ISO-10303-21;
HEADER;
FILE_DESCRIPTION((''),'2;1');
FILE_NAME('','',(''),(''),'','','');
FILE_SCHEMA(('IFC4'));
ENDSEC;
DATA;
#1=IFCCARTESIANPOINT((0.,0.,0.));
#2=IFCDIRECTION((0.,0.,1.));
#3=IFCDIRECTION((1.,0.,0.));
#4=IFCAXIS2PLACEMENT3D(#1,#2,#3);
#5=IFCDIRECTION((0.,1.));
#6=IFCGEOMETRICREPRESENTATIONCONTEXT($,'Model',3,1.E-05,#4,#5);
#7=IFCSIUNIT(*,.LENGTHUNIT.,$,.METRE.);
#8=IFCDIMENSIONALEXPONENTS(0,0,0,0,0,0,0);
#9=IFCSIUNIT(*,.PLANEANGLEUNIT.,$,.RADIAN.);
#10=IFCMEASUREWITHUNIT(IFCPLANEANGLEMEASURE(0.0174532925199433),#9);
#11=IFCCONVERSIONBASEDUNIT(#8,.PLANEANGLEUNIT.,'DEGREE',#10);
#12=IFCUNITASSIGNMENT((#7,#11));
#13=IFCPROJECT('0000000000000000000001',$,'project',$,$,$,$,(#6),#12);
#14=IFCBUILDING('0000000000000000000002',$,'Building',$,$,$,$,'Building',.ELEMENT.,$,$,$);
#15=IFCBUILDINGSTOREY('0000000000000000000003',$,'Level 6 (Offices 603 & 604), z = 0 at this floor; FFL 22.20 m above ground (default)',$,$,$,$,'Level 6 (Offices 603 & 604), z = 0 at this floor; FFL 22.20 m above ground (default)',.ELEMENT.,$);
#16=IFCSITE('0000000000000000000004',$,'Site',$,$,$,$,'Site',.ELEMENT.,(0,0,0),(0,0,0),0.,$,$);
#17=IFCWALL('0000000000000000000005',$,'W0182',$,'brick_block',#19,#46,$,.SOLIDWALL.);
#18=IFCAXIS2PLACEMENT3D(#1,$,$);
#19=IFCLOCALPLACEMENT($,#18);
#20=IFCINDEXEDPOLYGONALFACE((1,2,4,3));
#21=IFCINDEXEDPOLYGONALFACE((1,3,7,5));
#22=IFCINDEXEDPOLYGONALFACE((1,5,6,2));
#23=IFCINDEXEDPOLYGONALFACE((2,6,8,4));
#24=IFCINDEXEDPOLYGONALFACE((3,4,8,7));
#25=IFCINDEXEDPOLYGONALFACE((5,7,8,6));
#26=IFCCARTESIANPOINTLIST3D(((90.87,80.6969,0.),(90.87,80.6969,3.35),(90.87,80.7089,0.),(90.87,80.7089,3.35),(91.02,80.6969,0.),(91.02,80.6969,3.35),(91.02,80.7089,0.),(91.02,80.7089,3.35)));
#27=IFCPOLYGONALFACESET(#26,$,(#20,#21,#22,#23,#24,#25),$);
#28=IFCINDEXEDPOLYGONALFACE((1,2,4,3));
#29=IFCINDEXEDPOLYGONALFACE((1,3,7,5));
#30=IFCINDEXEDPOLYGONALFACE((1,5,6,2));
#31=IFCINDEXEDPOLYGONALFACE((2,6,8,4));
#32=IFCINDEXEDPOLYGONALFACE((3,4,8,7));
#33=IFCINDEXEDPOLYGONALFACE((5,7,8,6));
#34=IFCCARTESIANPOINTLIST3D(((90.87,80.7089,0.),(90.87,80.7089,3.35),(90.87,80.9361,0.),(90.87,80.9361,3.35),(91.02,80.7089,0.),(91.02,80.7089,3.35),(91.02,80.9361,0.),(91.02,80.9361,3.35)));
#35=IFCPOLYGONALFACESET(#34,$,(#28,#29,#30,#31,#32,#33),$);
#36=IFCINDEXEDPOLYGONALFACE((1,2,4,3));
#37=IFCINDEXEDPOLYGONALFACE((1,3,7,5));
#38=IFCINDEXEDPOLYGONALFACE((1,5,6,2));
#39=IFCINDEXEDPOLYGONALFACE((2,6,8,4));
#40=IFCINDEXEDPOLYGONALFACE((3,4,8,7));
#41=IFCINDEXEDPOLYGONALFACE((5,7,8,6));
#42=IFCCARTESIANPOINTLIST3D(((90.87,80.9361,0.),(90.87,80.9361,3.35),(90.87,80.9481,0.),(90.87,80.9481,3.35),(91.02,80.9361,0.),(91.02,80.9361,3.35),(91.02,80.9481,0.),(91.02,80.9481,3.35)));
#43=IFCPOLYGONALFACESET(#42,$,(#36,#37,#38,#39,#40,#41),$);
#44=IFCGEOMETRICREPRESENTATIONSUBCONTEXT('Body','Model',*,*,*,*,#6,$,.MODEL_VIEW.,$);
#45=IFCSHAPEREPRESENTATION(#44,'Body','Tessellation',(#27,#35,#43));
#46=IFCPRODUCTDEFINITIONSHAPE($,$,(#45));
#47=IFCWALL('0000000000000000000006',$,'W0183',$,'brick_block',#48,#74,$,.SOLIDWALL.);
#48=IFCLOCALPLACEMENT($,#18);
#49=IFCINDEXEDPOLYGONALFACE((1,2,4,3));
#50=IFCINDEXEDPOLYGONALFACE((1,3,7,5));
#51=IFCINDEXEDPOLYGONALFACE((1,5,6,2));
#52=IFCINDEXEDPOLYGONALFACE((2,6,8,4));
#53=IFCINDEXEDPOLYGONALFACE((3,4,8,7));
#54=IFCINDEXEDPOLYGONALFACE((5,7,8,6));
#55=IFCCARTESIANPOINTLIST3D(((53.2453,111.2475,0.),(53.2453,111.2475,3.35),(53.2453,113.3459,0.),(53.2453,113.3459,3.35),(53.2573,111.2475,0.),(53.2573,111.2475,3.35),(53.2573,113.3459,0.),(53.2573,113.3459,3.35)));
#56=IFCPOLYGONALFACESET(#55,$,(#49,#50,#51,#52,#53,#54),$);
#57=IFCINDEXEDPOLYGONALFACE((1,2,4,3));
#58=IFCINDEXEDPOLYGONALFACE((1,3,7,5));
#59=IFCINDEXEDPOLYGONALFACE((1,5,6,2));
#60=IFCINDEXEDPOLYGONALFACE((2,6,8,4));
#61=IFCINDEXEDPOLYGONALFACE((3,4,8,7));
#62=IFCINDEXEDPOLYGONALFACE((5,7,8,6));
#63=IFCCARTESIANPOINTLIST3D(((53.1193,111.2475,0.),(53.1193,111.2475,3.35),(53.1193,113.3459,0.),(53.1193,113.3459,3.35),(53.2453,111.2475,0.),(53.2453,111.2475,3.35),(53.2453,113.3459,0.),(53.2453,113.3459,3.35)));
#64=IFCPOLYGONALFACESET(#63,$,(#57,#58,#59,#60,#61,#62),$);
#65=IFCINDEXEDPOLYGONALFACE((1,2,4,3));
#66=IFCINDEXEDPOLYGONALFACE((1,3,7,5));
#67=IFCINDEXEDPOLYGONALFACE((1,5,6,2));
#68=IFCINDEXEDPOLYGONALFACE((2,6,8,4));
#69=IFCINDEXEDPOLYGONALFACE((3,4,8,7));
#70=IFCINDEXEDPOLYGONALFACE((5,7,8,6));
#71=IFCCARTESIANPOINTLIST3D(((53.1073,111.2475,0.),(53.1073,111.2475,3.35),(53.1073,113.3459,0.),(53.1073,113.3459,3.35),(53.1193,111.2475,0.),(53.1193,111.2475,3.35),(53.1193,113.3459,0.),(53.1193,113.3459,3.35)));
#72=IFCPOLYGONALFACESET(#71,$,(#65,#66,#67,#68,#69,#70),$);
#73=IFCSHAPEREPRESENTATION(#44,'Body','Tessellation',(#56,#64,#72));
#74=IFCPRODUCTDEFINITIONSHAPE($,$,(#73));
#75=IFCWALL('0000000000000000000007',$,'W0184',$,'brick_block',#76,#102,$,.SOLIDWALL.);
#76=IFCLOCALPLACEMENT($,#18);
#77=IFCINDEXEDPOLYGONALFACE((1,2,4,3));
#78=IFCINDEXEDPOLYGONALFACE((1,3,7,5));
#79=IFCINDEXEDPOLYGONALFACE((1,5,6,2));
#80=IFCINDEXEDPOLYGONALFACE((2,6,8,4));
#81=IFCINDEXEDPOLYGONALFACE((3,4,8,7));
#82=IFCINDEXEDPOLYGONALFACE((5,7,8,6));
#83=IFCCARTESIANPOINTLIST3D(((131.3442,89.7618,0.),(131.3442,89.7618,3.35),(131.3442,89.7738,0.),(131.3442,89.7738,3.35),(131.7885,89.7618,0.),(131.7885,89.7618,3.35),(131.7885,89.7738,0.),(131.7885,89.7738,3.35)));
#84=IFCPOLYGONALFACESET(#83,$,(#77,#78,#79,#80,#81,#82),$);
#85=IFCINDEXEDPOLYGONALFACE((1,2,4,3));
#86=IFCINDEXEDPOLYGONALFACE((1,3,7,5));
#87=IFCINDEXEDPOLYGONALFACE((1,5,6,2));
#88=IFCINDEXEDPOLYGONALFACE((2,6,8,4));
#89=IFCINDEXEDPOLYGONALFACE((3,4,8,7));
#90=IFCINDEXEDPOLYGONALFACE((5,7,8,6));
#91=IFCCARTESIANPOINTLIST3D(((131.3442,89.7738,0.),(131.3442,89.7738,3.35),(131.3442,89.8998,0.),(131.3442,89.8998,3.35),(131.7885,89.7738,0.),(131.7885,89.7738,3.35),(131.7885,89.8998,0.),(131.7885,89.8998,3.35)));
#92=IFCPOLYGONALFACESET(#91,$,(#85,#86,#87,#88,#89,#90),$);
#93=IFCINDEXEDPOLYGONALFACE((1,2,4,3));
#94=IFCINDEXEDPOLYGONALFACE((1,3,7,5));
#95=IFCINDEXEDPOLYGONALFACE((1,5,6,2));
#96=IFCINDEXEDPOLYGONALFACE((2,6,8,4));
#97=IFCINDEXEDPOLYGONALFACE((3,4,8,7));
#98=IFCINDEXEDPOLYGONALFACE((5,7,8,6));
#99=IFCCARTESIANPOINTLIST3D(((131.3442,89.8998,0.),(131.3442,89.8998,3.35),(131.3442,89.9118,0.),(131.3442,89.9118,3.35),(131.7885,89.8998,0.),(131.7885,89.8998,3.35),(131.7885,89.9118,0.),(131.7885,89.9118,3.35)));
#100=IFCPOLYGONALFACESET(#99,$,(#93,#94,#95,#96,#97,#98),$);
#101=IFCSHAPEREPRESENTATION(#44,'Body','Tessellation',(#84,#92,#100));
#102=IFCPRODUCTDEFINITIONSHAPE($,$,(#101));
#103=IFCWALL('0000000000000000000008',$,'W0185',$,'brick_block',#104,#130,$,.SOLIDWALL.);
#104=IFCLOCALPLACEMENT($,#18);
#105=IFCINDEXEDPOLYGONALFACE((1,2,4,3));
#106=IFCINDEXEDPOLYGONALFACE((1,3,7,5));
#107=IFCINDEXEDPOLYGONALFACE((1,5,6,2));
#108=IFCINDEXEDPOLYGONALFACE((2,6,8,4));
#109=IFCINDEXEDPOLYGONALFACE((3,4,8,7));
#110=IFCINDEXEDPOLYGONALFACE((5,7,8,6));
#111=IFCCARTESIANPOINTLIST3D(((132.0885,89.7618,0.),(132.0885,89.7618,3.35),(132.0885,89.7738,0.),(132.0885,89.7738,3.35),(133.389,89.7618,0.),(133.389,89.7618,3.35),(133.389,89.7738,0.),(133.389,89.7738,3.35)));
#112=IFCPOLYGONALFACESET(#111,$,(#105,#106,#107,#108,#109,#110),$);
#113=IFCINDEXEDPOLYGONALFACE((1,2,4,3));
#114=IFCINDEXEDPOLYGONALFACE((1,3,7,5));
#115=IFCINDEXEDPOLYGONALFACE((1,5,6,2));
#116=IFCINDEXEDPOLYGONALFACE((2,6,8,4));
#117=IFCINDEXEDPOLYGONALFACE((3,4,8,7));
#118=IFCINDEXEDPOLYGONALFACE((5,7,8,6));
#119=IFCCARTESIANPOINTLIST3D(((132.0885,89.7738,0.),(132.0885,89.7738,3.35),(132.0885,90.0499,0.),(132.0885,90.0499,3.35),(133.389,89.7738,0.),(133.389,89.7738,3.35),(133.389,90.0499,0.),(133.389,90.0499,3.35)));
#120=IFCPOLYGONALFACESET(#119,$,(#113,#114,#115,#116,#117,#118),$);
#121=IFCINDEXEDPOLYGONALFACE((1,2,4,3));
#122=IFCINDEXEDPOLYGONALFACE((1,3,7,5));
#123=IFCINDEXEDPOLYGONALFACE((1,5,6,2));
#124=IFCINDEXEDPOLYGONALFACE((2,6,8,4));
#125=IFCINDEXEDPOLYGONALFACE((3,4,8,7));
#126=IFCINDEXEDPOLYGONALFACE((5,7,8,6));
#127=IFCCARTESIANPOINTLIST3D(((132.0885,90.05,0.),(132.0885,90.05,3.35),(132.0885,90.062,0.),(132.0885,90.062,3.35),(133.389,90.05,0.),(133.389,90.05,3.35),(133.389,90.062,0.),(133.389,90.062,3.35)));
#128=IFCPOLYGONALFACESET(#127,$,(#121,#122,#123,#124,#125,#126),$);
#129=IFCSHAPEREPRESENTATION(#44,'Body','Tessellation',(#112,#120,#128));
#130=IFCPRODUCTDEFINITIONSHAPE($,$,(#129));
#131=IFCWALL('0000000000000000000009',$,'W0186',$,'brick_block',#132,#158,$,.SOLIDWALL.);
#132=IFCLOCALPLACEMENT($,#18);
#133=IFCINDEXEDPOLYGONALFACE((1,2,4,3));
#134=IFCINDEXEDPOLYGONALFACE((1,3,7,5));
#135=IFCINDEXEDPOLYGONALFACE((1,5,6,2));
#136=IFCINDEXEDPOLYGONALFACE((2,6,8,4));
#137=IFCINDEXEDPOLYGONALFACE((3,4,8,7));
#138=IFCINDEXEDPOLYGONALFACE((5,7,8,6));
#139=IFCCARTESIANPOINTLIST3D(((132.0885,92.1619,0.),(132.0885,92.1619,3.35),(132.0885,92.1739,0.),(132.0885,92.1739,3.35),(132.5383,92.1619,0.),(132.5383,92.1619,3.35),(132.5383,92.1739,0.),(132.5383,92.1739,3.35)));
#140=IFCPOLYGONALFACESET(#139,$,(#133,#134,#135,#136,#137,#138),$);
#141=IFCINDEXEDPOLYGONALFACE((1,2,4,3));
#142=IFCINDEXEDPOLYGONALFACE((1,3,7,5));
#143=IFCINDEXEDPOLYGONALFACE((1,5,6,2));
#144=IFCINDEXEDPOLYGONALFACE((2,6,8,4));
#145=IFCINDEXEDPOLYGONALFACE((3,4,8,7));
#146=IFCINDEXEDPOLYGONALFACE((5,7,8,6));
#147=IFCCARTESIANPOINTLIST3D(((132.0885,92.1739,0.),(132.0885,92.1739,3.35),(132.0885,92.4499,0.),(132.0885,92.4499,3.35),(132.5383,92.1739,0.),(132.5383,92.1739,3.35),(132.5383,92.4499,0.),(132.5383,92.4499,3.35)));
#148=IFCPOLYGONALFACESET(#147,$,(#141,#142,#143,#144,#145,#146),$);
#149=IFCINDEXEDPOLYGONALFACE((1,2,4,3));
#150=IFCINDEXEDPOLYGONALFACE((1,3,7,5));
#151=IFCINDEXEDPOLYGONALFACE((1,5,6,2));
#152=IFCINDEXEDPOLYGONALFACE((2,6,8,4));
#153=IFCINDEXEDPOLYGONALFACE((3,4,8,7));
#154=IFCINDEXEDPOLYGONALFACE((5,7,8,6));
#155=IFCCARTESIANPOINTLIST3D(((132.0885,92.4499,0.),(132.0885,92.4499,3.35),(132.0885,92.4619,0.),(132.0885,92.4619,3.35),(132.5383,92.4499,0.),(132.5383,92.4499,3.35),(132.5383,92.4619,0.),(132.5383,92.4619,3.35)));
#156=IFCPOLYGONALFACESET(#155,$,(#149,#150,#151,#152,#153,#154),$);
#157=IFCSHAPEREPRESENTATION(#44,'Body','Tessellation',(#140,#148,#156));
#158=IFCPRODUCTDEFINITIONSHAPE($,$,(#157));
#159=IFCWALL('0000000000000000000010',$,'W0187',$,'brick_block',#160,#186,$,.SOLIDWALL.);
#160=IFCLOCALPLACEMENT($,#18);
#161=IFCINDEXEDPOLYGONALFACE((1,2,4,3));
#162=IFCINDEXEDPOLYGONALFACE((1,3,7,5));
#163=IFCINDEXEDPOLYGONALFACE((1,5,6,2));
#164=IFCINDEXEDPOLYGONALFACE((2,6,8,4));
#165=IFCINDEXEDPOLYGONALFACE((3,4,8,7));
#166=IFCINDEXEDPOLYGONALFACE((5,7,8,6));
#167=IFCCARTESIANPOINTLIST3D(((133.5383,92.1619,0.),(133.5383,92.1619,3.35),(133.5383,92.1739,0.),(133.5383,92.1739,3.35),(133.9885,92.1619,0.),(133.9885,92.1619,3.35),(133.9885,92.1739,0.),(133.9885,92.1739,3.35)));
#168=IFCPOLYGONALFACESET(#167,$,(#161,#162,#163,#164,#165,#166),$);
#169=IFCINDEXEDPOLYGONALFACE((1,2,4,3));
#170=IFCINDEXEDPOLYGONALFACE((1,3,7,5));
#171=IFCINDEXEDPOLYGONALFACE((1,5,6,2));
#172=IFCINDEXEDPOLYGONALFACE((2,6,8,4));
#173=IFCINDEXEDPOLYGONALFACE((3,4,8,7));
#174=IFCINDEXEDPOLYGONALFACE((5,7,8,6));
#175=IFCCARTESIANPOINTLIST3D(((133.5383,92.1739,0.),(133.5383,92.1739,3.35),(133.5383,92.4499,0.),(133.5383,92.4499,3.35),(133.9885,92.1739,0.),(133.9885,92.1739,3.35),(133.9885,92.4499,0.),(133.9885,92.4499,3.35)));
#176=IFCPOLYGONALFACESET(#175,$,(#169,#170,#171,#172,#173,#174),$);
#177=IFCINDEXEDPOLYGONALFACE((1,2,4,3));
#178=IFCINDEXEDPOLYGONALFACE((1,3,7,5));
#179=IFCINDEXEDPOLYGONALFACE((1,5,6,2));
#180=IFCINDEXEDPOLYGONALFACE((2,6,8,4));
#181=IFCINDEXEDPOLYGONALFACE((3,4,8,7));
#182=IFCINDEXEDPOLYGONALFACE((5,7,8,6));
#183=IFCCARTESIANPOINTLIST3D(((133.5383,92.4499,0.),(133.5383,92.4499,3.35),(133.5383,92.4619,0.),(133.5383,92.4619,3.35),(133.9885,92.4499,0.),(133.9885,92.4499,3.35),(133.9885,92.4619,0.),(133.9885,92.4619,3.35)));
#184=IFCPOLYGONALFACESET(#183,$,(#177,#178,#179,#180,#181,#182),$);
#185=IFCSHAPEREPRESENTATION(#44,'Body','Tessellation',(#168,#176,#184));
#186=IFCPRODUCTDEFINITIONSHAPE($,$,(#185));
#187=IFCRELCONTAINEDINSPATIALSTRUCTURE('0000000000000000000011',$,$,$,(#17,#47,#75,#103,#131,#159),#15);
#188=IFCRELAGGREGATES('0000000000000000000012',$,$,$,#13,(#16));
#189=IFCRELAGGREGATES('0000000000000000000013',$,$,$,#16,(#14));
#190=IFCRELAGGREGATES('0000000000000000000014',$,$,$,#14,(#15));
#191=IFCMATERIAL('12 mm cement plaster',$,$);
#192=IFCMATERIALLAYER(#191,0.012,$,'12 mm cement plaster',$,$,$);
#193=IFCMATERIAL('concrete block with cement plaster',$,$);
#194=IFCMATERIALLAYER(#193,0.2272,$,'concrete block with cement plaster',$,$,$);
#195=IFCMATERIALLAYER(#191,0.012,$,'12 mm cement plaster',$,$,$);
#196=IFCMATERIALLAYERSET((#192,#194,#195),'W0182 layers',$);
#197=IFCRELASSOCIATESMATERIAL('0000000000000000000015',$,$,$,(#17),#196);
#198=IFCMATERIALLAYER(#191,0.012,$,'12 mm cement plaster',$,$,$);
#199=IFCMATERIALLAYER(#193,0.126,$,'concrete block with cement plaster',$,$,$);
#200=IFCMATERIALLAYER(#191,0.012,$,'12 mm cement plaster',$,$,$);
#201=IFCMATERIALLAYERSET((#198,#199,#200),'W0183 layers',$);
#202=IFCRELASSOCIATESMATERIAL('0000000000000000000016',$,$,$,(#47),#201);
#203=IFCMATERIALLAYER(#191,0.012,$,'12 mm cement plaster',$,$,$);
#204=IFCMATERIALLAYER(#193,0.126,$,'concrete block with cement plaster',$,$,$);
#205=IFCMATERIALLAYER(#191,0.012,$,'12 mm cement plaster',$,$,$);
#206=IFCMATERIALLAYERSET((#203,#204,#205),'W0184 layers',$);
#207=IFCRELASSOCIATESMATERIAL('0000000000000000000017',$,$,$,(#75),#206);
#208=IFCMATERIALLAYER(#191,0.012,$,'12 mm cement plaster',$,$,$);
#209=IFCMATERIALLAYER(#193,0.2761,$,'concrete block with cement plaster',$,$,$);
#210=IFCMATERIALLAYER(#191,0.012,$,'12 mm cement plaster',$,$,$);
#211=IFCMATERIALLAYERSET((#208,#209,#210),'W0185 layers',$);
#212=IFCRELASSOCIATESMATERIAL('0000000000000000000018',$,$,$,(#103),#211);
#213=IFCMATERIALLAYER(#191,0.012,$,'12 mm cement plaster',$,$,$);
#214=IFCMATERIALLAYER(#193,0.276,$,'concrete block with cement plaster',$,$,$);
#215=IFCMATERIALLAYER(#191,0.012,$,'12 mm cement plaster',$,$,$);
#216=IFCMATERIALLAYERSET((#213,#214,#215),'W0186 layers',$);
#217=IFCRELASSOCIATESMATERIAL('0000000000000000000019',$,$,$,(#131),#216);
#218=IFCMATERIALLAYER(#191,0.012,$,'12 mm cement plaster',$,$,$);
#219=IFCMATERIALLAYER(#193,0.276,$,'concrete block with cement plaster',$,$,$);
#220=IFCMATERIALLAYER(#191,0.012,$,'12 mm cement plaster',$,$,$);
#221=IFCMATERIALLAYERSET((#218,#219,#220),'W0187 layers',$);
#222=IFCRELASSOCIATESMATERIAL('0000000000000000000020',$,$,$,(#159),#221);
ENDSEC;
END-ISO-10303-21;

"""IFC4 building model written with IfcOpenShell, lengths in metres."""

from ifc_helpers import new_model, entity, si_unit, converted_unit, direction, frame, frame_2d, origin_with_axes, origin_2d_with_axis, place, context, subcontext, project, spatial, rectangle, extrude, material, layer, layer_set, layer_usage, element, save


model = new_model("IFC4")

# Units and contexts
model_context = context("Model", 3, precision=1e-05, world=origin_with_axes(), true_north=direction((0.0, 1.0)))
body_context = subcontext(model_context, "Body", "Model", "MODEL_VIEW")
ifc_project = project(units=[si_unit("LENGTHUNIT", "METRE"), converted_unit("PLANEANGLEUNIT", "DEGREE", entity("IfcPlaneAngleMeasure", 0.0174532925199433), si_unit("PLANEANGLEUNIT", "RADIAN"), dimensions=[0, 0, 0, 0, 0, 0, 0])], contexts=[model_context])

# Site, building, storey
site = spatial("IfcSite", under=ifc_project, Name="Site", LongName="Site", CompositionType="ELEMENT", RefLatitude=(0, 0, 0), RefLongitude=(0, 0, 0), RefElevation=0.0)
building = spatial("IfcBuilding", under=site, Name="Building", LongName="Building", CompositionType="ELEMENT")
storey = spatial("IfcBuildingStorey", under=building, Name="Level 6 (Offices 603 & 604), z = 0 at this floor; FFL 22.20 m above ground (default)", LongName="Level 6 (Offices 603 & 604), z = 0 at this floor; FFL 22.20 m above ground (default)", CompositionType="ELEMENT")

# Shared definitions
placement = place(None, origin_with_axes())

# Walls
ifc_material_1 = material(Name="12 mm cement plaster")
ifc_material_2 = material(Name="concrete block with cement plaster")
ifc_layer_1 = layer(ifc_material_1, 0.012, Name="12 mm cement plaster")
ifc_layer_2 = layer(ifc_material_2, 0.2272, Name="concrete block with cement plaster")
ifc_layer_3 = layer(ifc_material_1, 0.012, Name="12 mm cement plaster")
ifc_layer_set_1 = layer_set([ifc_layer_1, ifc_layer_2, ifc_layer_3], Name="W0182 layers")
ifc_layer_usage_1 = layer_usage(ifc_layer_set_1, "AXIS2", "POSITIVE", -0.1256)
element("IfcWall", 1, at=placement, inside=storey, material=ifc_layer_usage_1, Name="W0182", ObjectType="brick_block", PredefinedType="SOLIDWALL", context=body_context, shape_type="SweptSolid", body=[
    extrude(rectangle(XDim=0.15, YDim=0.012, at=frame_2d((0.0, 0.0), x_axis=(1.0, 0.0))), frame((90.945, 80.7029, 0.0), z_axis=(0.0, 0.0, 1.0), x_axis=(1.0, 0.0, 0.0)), (0.0, 0.0, 1.0), 3.35),
    extrude(rectangle(XDim=0.15, YDim=0.2272, at=frame_2d((0.0, 0.1196), x_axis=(1.0, 0.0))), frame((90.945, 80.7029, 0.0), z_axis=(0.0, 0.0, 1.0), x_axis=(1.0, 0.0, 0.0)), (0.0, 0.0, 1.0), 3.35),
    extrude(rectangle(XDim=0.15, YDim=0.012, at=frame_2d((0.0, 0.2392), x_axis=(1.0, 0.0))), frame((90.945, 80.7029, 0.0), z_axis=(0.0, 0.0, 1.0), x_axis=(1.0, 0.0, 0.0)), (0.0, 0.0, 1.0), 3.35),
])
ifc_layer_4 = layer(ifc_material_1, 0.012, Name="12 mm cement plaster")
ifc_layer_5 = layer(ifc_material_2, 0.126, Name="concrete block with cement plaster")
ifc_layer_6 = layer(ifc_material_1, 0.012, Name="12 mm cement plaster")
ifc_layer_set_2 = layer_set([ifc_layer_4, ifc_layer_5, ifc_layer_6], Name="W0183 layers")
ifc_layer_usage_2 = layer_usage(ifc_layer_set_2, "AXIS2", "POSITIVE", -0.075)
element("IfcWall", 2, at=placement, inside=storey, material=ifc_layer_usage_2, Name="W0183", ObjectType="brick_block", PredefinedType="SOLIDWALL", context=body_context, shape_type="SweptSolid", body=[
    extrude(rectangle(XDim=2.0984, YDim=0.012, at=frame_2d((0.0, 0.0), x_axis=(0.0, 1.0))), frame((53.2513, 112.2967, 0.0), z_axis=(0.0, 0.0, 1.0), x_axis=(1.0, 0.0, 0.0)), (0.0, 0.0, 1.0), 3.35),
    extrude(rectangle(XDim=2.0984, YDim=0.126, at=frame_2d((-0.069, 0.0), x_axis=(0.0, 1.0))), frame((53.2513, 112.2967, 0.0), z_axis=(0.0, 0.0, 1.0), x_axis=(1.0, 0.0, 0.0)), (0.0, 0.0, 1.0), 3.35),
    extrude(rectangle(XDim=2.0984, YDim=0.012, at=frame_2d((-0.138, 0.0), x_axis=(0.0, 1.0))), frame((53.2513, 112.2967, 0.0), z_axis=(0.0, 0.0, 1.0), x_axis=(1.0, 0.0, 0.0)), (0.0, 0.0, 1.0), 3.35),
])
ifc_layer_7 = layer(ifc_material_1, 0.012, Name="12 mm cement plaster")
ifc_layer_8 = layer(ifc_material_2, 0.126, Name="concrete block with cement plaster")
ifc_layer_9 = layer(ifc_material_1, 0.012, Name="12 mm cement plaster")
ifc_layer_set_3 = layer_set([ifc_layer_7, ifc_layer_8, ifc_layer_9], Name="W0184 layers")
ifc_layer_usage_3 = layer_usage(ifc_layer_set_3, "AXIS2", "POSITIVE", -0.075)
element("IfcWall", 3, at=placement, inside=storey, material=ifc_layer_usage_3, Name="W0184", ObjectType="brick_block", PredefinedType="SOLIDWALL", context=body_context, shape_type="SweptSolid", body=[
    extrude(rectangle(XDim=0.4443, YDim=0.012, at=frame_2d((0.0, 0.0), x_axis=(1.0, 0.0))), frame((131.5663, 89.7678, 0.0), z_axis=(0.0, 0.0, 1.0), x_axis=(1.0, 0.0, 0.0)), (0.0, 0.0, 1.0), 3.35),
    extrude(rectangle(XDim=0.4443, YDim=0.126, at=frame_2d((0.0, 0.069), x_axis=(1.0, 0.0))), frame((131.5663, 89.7678, 0.0), z_axis=(0.0, 0.0, 1.0), x_axis=(1.0, 0.0, 0.0)), (0.0, 0.0, 1.0), 3.35),
    extrude(rectangle(XDim=0.4443, YDim=0.012, at=frame_2d((0.0, 0.138), x_axis=(1.0, 0.0))), frame((131.5663, 89.7678, 0.0), z_axis=(0.0, 0.0, 1.0), x_axis=(1.0, 0.0, 0.0)), (0.0, 0.0, 1.0), 3.35),
])
ifc_layer_10 = layer(ifc_material_1, 0.012, Name="12 mm cement plaster")
ifc_layer_11 = layer(ifc_material_2, 0.2761, Name="concrete block with cement plaster")
ifc_layer_12 = layer(ifc_material_1, 0.012, Name="12 mm cement plaster")
ifc_layer_set_4 = layer_set([ifc_layer_10, ifc_layer_11, ifc_layer_12], Name="W0185 layers")
ifc_layer_usage_4 = layer_usage(ifc_layer_set_4, "AXIS2", "POSITIVE", -0.15)
element("IfcWall", 4, at=placement, inside=storey, material=ifc_layer_usage_4, Name="W0185", ObjectType="brick_block", PredefinedType="SOLIDWALL", context=body_context, shape_type="SweptSolid", body=[
    extrude(rectangle(XDim=1.3005, YDim=0.012, at=origin_2d_with_axis()), frame((132.7388, 89.7678, 0.0), z_axis=(0.0, 0.0, 1.0), x_axis=(1.0, 0.0, 0.0)), (0.0, 0.0, 1.0), 3.35),
    extrude(rectangle(XDim=1.3005, YDim=0.2761, at=frame_2d((0.0, 0.144), x_axis=(1.0, 0.0))), frame((132.7388, 89.7678, 0.0), z_axis=(0.0, 0.0, 1.0), x_axis=(1.0, 0.0, 0.0)), (0.0, 0.0, 1.0), 3.35),
    extrude(rectangle(XDim=1.3005, YDim=0.012, at=frame_2d((0.0, 0.2881), x_axis=(1.0, 0.0))), frame((132.7388, 89.7678, 0.0), z_axis=(0.0, 0.0, 1.0), x_axis=(1.0, 0.0, 0.0)), (0.0, 0.0, 1.0), 3.35),
])
ifc_layer_13 = layer(ifc_material_1, 0.012, Name="12 mm cement plaster")
ifc_layer_14 = layer(ifc_material_2, 0.276, Name="concrete block with cement plaster")
ifc_layer_15 = layer(ifc_material_1, 0.012, Name="12 mm cement plaster")
ifc_layer_set_5 = layer_set([ifc_layer_13, ifc_layer_14, ifc_layer_15], Name="W0186 layers")
ifc_layer_usage_5 = layer_usage(ifc_layer_set_5, "AXIS2", "POSITIVE", -0.15)
element("IfcWall", 5, at=placement, inside=storey, material=ifc_layer_usage_5, Name="W0186", ObjectType="brick_block", PredefinedType="SOLIDWALL", context=body_context, shape_type="SweptSolid", body=[
    extrude(rectangle(XDim=0.4498, YDim=0.012, at=frame_2d((0.0, 0.0), x_axis=(1.0, 0.0))), frame((132.3134, 92.1679, 0.0), z_axis=(0.0, 0.0, 1.0), x_axis=(1.0, 0.0, 0.0)), (0.0, 0.0, 1.0), 3.35),
    extrude(rectangle(XDim=0.4498, YDim=0.276, at=frame_2d((0.0, 0.144), x_axis=(1.0, 0.0))), frame((132.3134, 92.1679, 0.0), z_axis=(0.0, 0.0, 1.0), x_axis=(1.0, 0.0, 0.0)), (0.0, 0.0, 1.0), 3.35),
    extrude(rectangle(XDim=0.4498, YDim=0.012, at=frame_2d((0.0, 0.288), x_axis=(1.0, 0.0))), frame((132.3134, 92.1679, 0.0), z_axis=(0.0, 0.0, 1.0), x_axis=(1.0, 0.0, 0.0)), (0.0, 0.0, 1.0), 3.35),
])
ifc_layer_16 = layer(ifc_material_1, 0.012, Name="12 mm cement plaster")
ifc_layer_17 = layer(ifc_material_2, 0.276, Name="concrete block with cement plaster")
ifc_layer_18 = layer(ifc_material_1, 0.012, Name="12 mm cement plaster")
ifc_layer_set_6 = layer_set([ifc_layer_16, ifc_layer_17, ifc_layer_18], Name="W0187 layers")
ifc_layer_usage_6 = layer_usage(ifc_layer_set_6, "AXIS2", "POSITIVE", -0.15)
element("IfcWall", 6, at=placement, inside=storey, material=ifc_layer_usage_6, Name="W0187", ObjectType="brick_block", PredefinedType="SOLIDWALL", context=body_context, shape_type="SweptSolid", body=[
    extrude(rectangle(XDim=0.4502, YDim=0.012, at=frame_2d((0.0, 0.0), x_axis=(1.0, 0.0))), frame((133.7634, 92.1679, 0.0), z_axis=(0.0, 0.0, 1.0), x_axis=(1.0, 0.0, 0.0)), (0.0, 0.0, 1.0), 3.35),
    extrude(rectangle(XDim=0.4502, YDim=0.276, at=frame_2d((0.0, 0.144), x_axis=(1.0, 0.0))), frame((133.7634, 92.1679, 0.0), z_axis=(0.0, 0.0, 1.0), x_axis=(1.0, 0.0, 0.0)), (0.0, 0.0, 1.0), 3.35),
    extrude(rectangle(XDim=0.4502, YDim=0.012, at=frame_2d((0.0, 0.288), x_axis=(1.0, 0.0))), frame((133.7634, 92.1679, 0.0), z_axis=(0.0, 0.0, 1.0), x_axis=(1.0, 0.0, 0.0)), (0.0, 0.0, 1.0), 3.35),
])

save(model, "model.ifc")
